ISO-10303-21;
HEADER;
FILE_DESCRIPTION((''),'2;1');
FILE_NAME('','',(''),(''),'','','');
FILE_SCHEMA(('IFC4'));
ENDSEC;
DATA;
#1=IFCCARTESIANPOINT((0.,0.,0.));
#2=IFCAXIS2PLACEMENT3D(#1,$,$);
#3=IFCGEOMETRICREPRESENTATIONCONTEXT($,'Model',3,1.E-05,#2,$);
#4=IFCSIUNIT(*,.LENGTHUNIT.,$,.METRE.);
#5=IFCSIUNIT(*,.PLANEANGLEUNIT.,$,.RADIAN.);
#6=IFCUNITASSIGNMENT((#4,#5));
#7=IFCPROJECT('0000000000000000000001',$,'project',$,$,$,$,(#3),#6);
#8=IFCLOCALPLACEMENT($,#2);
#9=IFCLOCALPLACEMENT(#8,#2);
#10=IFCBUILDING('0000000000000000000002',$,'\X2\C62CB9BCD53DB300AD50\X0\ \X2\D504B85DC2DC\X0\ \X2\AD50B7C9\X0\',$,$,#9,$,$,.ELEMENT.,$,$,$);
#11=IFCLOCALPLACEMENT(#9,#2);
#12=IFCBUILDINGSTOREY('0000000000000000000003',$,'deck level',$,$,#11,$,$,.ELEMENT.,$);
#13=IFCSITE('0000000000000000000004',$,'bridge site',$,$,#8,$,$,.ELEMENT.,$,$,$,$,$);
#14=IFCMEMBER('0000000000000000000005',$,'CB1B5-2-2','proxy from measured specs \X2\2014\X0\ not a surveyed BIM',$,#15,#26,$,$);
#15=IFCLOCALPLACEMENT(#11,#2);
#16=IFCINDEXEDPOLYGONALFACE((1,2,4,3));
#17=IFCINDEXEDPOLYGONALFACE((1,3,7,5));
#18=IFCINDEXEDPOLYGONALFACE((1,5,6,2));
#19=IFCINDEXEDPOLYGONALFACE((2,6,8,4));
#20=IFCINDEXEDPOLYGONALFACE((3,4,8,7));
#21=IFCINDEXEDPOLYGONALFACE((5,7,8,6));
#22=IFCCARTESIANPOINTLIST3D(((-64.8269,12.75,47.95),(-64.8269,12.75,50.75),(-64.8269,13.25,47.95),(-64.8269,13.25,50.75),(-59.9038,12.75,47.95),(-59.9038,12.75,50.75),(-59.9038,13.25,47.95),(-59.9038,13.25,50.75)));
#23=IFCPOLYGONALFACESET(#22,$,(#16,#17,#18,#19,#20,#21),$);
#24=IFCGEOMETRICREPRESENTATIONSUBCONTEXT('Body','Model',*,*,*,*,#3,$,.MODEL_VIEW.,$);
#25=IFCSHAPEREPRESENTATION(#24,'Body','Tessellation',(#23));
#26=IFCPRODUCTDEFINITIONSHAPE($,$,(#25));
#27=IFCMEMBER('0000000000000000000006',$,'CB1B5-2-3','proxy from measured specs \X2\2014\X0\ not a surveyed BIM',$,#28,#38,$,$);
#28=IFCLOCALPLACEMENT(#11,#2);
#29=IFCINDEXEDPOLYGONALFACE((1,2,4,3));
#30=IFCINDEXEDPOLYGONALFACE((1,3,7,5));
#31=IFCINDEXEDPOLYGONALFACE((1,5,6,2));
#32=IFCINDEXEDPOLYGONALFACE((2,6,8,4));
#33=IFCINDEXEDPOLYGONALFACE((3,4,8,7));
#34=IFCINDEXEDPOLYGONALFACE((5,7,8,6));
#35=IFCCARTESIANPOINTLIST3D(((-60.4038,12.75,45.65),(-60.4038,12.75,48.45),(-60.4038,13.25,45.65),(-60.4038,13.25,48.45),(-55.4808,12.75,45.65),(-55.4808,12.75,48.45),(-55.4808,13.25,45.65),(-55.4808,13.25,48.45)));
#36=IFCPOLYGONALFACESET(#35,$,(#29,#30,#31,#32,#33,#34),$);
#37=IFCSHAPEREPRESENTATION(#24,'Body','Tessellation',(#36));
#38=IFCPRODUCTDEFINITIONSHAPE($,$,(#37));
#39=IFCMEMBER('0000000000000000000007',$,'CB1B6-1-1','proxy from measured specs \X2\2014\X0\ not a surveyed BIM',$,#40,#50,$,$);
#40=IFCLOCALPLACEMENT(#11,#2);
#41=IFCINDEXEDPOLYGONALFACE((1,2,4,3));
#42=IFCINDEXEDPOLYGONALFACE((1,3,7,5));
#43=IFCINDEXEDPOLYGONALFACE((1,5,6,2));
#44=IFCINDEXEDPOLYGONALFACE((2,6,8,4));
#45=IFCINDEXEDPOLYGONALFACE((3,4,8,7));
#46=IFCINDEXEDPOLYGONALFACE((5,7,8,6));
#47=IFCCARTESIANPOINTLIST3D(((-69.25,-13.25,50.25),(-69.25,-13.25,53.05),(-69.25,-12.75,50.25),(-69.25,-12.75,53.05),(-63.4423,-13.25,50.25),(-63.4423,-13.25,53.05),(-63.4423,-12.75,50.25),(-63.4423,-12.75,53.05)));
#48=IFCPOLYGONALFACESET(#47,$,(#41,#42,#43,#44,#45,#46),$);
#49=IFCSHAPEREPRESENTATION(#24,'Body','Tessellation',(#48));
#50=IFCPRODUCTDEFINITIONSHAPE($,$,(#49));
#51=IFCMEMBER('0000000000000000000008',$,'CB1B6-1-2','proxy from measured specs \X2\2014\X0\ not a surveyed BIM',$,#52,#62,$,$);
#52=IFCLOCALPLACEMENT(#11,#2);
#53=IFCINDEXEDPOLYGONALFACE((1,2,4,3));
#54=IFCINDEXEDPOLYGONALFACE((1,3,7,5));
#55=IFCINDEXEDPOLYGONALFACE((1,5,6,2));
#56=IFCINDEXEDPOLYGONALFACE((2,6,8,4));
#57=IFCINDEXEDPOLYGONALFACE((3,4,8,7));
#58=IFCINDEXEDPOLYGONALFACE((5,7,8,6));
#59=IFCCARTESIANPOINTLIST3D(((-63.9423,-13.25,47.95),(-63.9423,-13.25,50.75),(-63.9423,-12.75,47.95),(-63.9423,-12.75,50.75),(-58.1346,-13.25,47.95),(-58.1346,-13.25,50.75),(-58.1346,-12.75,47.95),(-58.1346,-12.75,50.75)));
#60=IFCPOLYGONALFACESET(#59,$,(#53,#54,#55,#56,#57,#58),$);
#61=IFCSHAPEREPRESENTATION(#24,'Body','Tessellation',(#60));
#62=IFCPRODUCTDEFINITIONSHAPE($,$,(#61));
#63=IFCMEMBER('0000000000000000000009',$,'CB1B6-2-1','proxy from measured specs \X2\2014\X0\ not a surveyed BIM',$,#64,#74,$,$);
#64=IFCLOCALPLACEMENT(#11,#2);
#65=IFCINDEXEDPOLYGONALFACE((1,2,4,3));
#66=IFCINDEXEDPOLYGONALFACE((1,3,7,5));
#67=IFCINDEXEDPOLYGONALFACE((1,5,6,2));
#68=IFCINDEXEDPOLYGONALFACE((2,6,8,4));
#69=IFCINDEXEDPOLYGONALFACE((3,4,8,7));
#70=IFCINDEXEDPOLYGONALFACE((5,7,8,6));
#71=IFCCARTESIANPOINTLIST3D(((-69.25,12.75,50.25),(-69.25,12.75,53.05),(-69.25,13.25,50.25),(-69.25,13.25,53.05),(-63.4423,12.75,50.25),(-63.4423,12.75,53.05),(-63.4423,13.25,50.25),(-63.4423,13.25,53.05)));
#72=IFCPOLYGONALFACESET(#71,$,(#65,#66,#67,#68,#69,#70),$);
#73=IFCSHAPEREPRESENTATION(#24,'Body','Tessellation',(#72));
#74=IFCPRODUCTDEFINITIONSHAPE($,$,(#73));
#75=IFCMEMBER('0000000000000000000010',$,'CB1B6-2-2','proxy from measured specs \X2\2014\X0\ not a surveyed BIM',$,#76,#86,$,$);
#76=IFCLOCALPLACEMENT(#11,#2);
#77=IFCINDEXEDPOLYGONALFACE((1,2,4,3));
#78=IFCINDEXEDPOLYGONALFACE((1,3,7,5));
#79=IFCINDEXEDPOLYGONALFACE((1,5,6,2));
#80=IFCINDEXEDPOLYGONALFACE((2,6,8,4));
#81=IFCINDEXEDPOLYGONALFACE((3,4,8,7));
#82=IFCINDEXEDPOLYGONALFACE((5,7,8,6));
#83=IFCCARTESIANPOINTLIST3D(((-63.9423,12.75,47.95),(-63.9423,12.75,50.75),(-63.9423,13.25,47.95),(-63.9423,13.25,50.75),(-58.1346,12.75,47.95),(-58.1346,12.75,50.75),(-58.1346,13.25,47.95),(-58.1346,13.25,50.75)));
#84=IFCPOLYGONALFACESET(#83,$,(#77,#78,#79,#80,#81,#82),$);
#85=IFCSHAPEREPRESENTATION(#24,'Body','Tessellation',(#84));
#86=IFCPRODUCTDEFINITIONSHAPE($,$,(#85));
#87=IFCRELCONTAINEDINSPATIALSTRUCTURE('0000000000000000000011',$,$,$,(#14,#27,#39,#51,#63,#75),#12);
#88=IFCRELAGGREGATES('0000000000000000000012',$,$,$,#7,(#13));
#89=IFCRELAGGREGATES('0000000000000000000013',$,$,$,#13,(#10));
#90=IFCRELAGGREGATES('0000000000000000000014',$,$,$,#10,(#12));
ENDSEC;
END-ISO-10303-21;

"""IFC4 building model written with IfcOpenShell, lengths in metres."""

from ifc_helpers import new_model, si_unit, frame, origin, origin_2d, place, context, subcontext, project, spatial, rectangle, extrude, element, save


model = new_model("IFC4")

# Units and contexts
model_context = context("Model", 3, precision=1e-05, world=origin())
body_context = subcontext(model_context, "Body", "Model", "MODEL_VIEW")
ifc_project = project(units=[si_unit("LENGTHUNIT", "METRE"), si_unit("PLANEANGLEUNIT", "RADIAN")], contexts=[model_context])

# Site, building, storey
site_placement = place(None, origin())
site = spatial("IfcSite", under=ifc_project, at=site_placement, Name="bridge site", CompositionType="ELEMENT")
building_placement = place(site_placement, origin())
building = spatial("IfcBuilding", under=site, at=building_placement, Name="올림픽대교 프록시 교량", CompositionType="ELEMENT")
storey_placement = place(building_placement, origin())
storey = spatial("IfcBuildingStorey", under=building, at=storey_placement, Name="deck level", CompositionType="ELEMENT")

# Members
member_1_placement = place(storey_placement, frame((-62.3654, 13.0, 47.95)))
element("IfcMember", 1, at=member_1_placement, inside=storey, Name="CB1B5-2-2", Description="proxy from measured specs — not a surveyed BIM", context=body_context, shape_type="SweptSolid", body=[
    extrude(rectangle(XDim=4.9231, YDim=0.5, at=origin_2d()), origin(), (0.0, 0.0, 1.0), 2.8),
])
member_2_placement = place(storey_placement, frame((-57.9423, 13.0, 45.65)))
element("IfcMember", 2, at=member_2_placement, inside=storey, Name="CB1B5-2-3", Description="proxy from measured specs — not a surveyed BIM", context=body_context, shape_type="SweptSolid", body=[
    extrude(rectangle(XDim=4.9231, YDim=0.5, at=origin_2d()), origin(), (0.0, 0.0, 1.0), 2.8),
])
member_3_placement = place(storey_placement, frame((-66.3462, -13.0, 50.25)))
element("IfcMember", 3, at=member_3_placement, inside=storey, Name="CB1B6-1-1", Description="proxy from measured specs — not a surveyed BIM", context=body_context, shape_type="SweptSolid", body=[
    extrude(rectangle(XDim=5.8077, YDim=0.5, at=origin_2d()), origin(), (0.0, 0.0, 1.0), 2.8),
])
member_4_placement = place(storey_placement, frame((-61.0385, -13.0, 47.95)))
element("IfcMember", 4, at=member_4_placement, inside=storey, Name="CB1B6-1-2", Description="proxy from measured specs — not a surveyed BIM", context=body_context, shape_type="SweptSolid", body=[
    extrude(rectangle(XDim=5.8077, YDim=0.5, at=origin_2d()), origin(), (0.0, 0.0, 1.0), 2.8),
])
member_5_placement = place(storey_placement, frame((-66.3462, 13.0, 50.25)))
element("IfcMember", 5, at=member_5_placement, inside=storey, Name="CB1B6-2-1", Description="proxy from measured specs — not a surveyed BIM", context=body_context, shape_type="SweptSolid", body=[
    extrude(rectangle(XDim=5.8077, YDim=0.5, at=origin_2d()), origin(), (0.0, 0.0, 1.0), 2.8),
])
member_6_placement = place(storey_placement, frame((-61.0385, 13.0, 47.95)))
element("IfcMember", 6, at=member_6_placement, inside=storey, Name="CB1B6-2-2", Description="proxy from measured specs — not a surveyed BIM", context=body_context, shape_type="SweptSolid", body=[
    extrude(rectangle(XDim=5.8077, YDim=0.5, at=origin_2d()), origin(), (0.0, 0.0, 1.0), 2.8),
])

save(model, "model.ifc")
